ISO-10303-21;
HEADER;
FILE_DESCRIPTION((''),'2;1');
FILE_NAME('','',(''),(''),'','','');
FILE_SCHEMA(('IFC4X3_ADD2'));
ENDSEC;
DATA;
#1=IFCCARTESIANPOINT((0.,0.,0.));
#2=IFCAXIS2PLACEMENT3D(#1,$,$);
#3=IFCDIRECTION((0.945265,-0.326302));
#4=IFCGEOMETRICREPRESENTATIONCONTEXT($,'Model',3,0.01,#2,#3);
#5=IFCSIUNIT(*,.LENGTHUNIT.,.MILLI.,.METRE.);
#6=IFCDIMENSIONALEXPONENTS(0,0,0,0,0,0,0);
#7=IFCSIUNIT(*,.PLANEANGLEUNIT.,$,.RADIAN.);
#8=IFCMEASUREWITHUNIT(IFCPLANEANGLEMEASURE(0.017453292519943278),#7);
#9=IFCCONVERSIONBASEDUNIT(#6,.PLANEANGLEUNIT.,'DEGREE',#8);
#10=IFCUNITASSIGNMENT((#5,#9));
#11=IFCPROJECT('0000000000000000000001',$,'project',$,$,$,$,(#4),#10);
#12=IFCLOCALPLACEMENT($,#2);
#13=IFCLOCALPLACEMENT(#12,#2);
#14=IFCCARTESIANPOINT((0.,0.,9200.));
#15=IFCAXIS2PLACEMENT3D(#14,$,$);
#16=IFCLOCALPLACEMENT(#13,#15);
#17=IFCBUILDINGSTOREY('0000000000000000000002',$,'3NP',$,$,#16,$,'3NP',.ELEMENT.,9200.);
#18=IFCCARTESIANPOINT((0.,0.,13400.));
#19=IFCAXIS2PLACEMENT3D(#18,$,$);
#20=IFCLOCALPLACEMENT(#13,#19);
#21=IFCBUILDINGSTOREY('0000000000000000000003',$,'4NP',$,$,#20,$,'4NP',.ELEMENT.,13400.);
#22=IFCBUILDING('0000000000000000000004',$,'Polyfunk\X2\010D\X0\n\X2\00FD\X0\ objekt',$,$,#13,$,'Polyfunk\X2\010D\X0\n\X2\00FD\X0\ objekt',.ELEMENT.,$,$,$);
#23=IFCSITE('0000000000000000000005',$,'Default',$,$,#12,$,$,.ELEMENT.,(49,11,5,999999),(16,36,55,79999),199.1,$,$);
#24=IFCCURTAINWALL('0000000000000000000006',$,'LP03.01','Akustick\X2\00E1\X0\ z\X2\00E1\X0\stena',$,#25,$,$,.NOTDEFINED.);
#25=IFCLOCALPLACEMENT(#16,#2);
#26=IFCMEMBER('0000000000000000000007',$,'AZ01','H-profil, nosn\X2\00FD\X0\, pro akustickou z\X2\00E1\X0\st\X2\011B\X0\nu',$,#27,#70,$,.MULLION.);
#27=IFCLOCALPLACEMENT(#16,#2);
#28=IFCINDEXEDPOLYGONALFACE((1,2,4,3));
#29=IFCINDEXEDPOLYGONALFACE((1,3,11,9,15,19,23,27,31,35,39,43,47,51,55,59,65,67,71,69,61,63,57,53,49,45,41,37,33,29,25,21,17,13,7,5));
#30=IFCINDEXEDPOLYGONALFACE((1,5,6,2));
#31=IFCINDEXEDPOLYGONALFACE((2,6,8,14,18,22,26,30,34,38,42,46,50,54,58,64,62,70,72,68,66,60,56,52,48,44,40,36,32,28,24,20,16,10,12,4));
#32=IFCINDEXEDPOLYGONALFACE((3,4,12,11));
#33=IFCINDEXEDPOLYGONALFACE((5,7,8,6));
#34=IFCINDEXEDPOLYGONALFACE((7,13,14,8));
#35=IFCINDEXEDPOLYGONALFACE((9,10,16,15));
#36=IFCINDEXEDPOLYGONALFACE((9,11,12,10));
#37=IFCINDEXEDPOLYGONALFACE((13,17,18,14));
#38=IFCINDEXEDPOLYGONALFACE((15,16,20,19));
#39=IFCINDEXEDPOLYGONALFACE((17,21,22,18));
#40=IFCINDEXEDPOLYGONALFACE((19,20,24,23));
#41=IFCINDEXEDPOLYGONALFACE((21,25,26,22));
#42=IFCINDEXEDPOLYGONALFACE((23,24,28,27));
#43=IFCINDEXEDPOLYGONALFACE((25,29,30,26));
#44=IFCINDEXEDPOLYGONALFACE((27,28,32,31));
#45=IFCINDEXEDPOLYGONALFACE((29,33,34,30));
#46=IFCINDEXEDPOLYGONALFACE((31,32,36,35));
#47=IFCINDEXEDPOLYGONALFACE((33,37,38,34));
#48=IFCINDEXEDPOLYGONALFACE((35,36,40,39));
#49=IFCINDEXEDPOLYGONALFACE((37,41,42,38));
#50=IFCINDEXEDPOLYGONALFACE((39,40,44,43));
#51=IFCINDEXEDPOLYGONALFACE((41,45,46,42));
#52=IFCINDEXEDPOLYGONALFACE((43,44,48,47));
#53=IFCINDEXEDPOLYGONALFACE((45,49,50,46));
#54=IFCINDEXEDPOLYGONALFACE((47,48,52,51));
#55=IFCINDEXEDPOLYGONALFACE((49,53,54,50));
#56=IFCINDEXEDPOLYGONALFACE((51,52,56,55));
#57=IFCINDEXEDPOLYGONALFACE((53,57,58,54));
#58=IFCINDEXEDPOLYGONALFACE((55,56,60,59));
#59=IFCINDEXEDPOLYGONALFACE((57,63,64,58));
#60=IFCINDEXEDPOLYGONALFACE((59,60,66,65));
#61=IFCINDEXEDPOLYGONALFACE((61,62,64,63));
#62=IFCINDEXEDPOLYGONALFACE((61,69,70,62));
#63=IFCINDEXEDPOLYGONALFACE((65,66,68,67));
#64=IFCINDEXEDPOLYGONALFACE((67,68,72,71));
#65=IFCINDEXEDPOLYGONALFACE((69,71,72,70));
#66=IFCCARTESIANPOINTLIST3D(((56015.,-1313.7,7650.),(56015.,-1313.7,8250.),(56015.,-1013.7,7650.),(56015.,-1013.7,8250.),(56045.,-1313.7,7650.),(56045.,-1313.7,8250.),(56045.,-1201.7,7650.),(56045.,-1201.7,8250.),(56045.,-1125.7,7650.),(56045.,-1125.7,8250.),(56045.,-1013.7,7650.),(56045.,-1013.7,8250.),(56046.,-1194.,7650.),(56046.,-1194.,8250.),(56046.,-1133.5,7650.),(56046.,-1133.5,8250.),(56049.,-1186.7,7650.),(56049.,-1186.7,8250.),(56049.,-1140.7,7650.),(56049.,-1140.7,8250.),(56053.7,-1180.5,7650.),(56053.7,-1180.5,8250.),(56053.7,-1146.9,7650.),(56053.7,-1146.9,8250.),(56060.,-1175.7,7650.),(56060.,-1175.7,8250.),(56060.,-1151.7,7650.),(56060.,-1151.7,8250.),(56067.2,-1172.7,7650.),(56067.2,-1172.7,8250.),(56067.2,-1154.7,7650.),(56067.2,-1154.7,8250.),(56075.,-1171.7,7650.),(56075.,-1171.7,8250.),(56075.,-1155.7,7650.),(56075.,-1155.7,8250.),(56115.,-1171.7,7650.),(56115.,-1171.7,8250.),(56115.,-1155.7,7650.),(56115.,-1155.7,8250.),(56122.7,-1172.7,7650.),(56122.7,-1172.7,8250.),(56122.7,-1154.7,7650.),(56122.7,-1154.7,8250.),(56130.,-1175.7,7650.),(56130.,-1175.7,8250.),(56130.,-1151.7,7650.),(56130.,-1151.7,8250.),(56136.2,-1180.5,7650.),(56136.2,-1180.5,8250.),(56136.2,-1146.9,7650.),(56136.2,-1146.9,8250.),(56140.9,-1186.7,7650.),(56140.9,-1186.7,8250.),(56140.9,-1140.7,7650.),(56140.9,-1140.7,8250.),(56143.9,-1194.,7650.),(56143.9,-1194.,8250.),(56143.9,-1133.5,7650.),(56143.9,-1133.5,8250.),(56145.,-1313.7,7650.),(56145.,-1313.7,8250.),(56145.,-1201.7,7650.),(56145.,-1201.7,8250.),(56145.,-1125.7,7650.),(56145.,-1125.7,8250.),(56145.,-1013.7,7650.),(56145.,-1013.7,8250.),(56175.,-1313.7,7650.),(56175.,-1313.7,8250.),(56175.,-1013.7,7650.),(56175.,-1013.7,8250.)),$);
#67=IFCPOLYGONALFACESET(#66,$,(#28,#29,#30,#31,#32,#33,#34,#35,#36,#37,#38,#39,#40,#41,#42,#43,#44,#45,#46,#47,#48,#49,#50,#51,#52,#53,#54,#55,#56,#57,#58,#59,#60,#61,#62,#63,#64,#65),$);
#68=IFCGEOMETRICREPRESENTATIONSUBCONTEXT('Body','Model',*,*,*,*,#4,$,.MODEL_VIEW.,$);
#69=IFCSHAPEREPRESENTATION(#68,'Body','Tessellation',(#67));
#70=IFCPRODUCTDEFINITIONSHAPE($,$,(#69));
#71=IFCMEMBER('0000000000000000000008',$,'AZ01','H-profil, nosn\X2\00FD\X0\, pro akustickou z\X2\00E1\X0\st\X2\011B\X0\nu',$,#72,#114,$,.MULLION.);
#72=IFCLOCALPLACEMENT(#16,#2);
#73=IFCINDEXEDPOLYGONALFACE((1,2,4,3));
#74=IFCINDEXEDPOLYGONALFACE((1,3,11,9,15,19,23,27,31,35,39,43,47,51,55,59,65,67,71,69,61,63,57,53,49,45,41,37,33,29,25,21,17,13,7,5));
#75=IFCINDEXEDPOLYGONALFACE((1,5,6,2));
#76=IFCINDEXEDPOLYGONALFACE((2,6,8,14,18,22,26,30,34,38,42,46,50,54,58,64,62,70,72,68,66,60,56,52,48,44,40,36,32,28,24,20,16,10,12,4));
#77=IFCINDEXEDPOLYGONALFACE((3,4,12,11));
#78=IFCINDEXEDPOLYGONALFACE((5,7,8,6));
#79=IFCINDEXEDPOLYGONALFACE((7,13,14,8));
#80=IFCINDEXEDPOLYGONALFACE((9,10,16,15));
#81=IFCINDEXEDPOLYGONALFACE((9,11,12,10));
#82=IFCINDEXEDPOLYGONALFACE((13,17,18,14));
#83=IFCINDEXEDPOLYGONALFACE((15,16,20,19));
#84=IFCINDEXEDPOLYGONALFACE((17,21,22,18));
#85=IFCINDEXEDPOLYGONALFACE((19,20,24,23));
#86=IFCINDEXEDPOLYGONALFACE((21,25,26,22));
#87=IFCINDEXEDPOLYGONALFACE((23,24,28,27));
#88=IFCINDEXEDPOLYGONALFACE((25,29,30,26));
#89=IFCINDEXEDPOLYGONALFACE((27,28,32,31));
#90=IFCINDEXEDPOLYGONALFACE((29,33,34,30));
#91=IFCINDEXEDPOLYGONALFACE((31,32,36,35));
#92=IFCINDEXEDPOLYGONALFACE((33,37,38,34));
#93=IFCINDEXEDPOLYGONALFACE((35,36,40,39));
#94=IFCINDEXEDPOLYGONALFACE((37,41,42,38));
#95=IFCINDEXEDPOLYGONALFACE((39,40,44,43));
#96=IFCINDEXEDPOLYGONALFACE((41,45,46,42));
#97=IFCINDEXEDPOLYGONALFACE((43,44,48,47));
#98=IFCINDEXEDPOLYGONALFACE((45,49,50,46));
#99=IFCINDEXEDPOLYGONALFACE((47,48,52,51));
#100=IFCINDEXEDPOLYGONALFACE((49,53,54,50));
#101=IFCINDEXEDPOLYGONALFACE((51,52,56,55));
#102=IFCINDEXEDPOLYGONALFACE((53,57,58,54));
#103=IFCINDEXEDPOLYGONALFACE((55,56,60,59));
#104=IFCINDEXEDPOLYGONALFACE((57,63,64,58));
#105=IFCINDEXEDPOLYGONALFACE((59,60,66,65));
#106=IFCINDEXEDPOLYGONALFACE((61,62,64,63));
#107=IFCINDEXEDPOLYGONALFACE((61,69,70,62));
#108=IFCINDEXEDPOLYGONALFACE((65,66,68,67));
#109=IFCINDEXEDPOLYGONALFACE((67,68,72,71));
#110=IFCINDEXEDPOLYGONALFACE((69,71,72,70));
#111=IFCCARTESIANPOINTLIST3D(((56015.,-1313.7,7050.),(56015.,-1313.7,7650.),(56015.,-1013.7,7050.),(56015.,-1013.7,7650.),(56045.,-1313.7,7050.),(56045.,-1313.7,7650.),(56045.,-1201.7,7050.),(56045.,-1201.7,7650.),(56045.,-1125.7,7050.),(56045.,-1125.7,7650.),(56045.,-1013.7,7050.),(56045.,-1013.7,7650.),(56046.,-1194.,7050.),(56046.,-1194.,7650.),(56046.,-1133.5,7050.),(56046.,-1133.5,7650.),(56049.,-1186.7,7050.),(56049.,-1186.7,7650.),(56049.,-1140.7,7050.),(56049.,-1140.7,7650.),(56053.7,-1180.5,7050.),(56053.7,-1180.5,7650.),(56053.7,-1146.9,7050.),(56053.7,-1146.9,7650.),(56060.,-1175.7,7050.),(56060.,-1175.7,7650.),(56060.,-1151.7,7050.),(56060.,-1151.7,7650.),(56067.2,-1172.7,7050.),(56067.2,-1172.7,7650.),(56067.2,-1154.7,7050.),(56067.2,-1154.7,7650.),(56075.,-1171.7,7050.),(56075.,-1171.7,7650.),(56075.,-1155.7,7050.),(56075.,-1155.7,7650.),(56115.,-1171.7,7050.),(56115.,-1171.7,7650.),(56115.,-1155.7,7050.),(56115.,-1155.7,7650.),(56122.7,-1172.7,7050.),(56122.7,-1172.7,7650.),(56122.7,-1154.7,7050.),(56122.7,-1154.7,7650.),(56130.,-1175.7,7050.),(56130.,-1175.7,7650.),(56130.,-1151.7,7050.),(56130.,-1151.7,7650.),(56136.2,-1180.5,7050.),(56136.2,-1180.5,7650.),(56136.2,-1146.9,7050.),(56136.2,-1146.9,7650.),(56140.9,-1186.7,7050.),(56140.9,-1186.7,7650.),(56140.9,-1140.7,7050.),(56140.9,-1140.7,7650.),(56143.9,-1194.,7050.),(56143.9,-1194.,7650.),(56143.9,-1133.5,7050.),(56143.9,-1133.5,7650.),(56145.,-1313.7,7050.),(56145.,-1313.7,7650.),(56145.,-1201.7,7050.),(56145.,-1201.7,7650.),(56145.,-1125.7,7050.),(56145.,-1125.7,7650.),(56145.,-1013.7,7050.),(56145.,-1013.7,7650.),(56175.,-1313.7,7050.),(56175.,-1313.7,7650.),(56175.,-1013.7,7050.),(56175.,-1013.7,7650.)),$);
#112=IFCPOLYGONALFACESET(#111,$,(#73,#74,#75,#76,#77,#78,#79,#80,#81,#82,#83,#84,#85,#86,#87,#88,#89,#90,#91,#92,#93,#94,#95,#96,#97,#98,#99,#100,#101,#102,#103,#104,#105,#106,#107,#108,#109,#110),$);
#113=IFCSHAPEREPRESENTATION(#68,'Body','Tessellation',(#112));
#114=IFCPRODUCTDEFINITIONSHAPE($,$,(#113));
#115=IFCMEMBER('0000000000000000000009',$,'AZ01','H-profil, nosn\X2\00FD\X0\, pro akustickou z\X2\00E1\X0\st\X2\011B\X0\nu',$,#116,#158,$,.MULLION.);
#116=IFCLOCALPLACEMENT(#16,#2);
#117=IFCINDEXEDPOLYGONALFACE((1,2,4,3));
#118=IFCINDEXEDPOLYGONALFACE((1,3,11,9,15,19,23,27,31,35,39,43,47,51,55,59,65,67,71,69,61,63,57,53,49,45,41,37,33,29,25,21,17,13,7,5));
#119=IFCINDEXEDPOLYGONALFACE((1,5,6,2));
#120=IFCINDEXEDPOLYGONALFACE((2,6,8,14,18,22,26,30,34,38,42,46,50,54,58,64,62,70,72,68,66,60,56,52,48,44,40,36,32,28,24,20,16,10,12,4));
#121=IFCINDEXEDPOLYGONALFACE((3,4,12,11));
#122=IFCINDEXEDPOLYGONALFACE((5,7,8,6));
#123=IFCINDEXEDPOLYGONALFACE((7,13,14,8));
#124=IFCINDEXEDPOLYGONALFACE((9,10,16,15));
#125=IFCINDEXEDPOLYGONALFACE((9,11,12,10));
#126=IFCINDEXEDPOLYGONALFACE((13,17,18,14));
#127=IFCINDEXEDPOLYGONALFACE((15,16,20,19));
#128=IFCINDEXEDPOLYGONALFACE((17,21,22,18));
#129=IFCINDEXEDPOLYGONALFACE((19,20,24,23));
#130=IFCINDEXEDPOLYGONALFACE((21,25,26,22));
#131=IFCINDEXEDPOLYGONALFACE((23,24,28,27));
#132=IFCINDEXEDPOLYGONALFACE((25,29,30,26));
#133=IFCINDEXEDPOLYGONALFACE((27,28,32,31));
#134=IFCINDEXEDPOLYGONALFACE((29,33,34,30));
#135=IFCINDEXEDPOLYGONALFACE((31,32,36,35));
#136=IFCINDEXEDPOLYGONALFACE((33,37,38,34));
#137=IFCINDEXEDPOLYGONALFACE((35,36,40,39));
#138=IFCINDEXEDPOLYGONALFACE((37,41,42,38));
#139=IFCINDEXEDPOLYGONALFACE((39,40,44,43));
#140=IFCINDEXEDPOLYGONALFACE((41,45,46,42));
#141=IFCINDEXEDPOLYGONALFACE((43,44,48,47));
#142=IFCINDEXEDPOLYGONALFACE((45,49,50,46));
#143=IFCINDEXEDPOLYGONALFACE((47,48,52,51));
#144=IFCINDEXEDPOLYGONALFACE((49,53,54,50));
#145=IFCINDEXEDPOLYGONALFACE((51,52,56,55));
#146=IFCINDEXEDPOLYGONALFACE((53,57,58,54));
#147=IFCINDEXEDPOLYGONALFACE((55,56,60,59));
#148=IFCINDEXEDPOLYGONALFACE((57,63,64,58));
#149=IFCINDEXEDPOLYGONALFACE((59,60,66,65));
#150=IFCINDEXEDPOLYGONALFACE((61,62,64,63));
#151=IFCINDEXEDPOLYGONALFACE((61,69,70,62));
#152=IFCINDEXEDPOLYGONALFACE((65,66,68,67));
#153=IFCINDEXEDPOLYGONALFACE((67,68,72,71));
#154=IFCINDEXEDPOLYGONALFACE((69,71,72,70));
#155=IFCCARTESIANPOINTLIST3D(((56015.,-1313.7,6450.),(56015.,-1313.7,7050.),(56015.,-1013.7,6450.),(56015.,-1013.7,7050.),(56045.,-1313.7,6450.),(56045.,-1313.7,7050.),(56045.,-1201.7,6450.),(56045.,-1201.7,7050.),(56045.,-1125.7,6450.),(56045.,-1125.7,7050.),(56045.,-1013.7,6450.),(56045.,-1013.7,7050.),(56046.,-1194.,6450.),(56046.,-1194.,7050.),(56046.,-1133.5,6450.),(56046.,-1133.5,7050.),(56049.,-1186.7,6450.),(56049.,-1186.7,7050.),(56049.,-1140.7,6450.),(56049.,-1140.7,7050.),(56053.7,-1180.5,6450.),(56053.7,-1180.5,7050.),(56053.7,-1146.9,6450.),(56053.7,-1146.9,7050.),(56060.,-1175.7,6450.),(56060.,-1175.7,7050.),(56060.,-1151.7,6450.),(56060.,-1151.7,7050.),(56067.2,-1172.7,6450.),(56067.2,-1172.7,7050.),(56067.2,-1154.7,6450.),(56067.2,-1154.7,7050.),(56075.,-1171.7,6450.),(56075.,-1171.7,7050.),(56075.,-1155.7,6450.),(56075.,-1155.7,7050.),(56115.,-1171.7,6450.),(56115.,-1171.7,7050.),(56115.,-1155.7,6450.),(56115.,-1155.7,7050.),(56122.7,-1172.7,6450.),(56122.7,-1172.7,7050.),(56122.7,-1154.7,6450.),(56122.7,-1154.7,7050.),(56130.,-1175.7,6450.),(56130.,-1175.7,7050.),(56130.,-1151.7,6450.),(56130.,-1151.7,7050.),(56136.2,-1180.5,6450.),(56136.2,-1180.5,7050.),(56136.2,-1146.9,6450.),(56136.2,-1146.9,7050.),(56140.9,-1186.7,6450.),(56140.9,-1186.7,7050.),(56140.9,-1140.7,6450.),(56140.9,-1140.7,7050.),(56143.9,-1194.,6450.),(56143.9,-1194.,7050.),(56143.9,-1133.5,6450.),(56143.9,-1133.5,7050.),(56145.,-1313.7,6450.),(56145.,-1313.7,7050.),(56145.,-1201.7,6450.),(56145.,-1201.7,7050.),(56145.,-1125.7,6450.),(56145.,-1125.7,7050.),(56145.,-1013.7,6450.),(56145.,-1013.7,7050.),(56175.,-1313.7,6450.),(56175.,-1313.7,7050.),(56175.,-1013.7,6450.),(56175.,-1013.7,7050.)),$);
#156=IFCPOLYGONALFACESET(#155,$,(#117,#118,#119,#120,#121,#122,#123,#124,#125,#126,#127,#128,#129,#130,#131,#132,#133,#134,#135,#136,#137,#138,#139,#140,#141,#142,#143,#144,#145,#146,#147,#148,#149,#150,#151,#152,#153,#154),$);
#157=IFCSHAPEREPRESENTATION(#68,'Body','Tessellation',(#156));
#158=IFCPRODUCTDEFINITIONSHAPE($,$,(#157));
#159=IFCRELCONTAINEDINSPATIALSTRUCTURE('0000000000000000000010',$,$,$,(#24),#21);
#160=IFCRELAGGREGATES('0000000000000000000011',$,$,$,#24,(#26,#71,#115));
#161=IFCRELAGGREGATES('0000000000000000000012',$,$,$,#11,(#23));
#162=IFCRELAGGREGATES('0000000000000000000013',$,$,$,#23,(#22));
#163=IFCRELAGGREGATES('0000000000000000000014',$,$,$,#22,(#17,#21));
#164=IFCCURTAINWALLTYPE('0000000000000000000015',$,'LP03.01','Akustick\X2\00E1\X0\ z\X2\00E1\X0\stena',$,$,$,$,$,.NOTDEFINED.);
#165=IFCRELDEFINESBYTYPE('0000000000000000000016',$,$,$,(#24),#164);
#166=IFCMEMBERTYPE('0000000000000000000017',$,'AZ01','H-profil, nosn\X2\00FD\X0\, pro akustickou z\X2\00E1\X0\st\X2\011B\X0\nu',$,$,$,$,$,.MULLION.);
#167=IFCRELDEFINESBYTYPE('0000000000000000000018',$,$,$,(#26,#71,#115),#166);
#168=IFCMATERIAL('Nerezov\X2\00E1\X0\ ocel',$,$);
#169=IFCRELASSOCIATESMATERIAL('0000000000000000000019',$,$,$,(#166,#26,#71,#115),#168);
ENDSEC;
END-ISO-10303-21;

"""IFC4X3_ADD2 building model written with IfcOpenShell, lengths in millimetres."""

from ifc_helpers import new_model, entity, si_unit, converted_unit, direction, frame, frame_2d, origin, place, context, subcontext, project, spatial, polyline, circle_curve, parameter, trimmed, segment, composite_curve, outline, extrude, source, transform, mapped, material, material_profile, profile_set, profile_usage, type_object, element, aggregate, save


model = new_model("IFC4X3_ADD2")

# Units and contexts
model_context = context("Model", 3, precision=0.01, world=origin(), true_north=direction((0.945265, -0.326302)))
body_context = subcontext(model_context, "Body", "Model", "MODEL_VIEW")
ifc_project = project(units=[si_unit("LENGTHUNIT", "METRE", prefix="MILLI"), converted_unit("PLANEANGLEUNIT", "DEGREE", entity("IfcPlaneAngleMeasure", 0.017453292519943278), si_unit("PLANEANGLEUNIT", "RADIAN"), dimensions=[0, 0, 0, 0, 0, 0, 0])], contexts=[model_context])

# Site, building, storey
site_placement = place(None, origin())
site = spatial("IfcSite", under=ifc_project, at=site_placement, Name="Default", CompositionType="ELEMENT", RefLatitude=(49, 11, 5, 999999), RefLongitude=(16, 36, 55, 79999), RefElevation=199.1)
building_placement = place(site_placement, origin())
building = spatial("IfcBuilding", under=site, at=building_placement, Name="Polyfunkčný objekt", LongName="Polyfunkčný objekt", CompositionType="ELEMENT")
storey_1_placement = place(building_placement, frame((0.0, 0.0, 9200.0)))
storey_1 = spatial("IfcBuildingStorey", under=building, at=storey_1_placement, Name="3NP", LongName="3NP", CompositionType="ELEMENT", Elevation=9200.0)

# Shared definitions
storey_2_placement = place(building_placement, frame((0.0, 0.0, 13400.0)))
storey_2 = spatial("IfcBuildingStorey", under=building, at=storey_2_placement, Name="4NP", LongName="4NP", CompositionType="ELEMENT", Elevation=13400.0)

# Curtain wall, members
curtain_wall_type_1 = type_object("IfcCurtainWallType", Name="LP03.01", Description="Akustická zástena", PredefinedType="NOTDEFINED")
ifc_material_1 = material(Name="Nerezová ocel")
ifc_material_profile_1 = material_profile(ifc_material_1, outline(composite_curve([segment(polyline([(50.0, -150.0), (80.0, -150.0)]), True, "CONTINUOUS"), segment(polyline([(80.0, -150.0), (80.0, 150.0)]), True, "CONTINUOUS"), segment(polyline([(80.0, 150.0), (50.0, 150.0)]), True, "CONTINUOUS"), segment(polyline([(50.0, 150.0), (50.0, 38.0)]), True, "CONTINUOUS"), segment(trimmed(circle_curve(frame_2d((20.0, 38.0), x_axis=(0.0, 1.0)), 30.0), [parameter(180.0)], [parameter(270.0)], True, "PARAMETER"), False, "CONTINUOUS"), segment(polyline([(20.0, 8.0), (-20.0, 8.0)]), True, "CONTINUOUS"), segment(trimmed(circle_curve(frame_2d((-20.0, 38.0), x_axis=(0.0, 1.0)), 30.0), [parameter(90.0)], [parameter(180.0)], True, "PARAMETER"), False, "CONTINUOUS"), segment(polyline([(-50.0, 38.0), (-50.0, 150.0)]), True, "CONTINUOUS"), segment(polyline([(-50.0, 150.0), (-80.0, 150.0)]), True, "CONTINUOUS"), segment(polyline([(-80.0, 150.0), (-80.0, -150.0)]), True, "CONTINUOUS"), segment(polyline([(-80.0, -150.0), (-50.0, -150.0)]), True, "CONTINUOUS"), segment(polyline([(-50.0, -150.0), (-50.0, -38.0)]), True, "CONTINUOUS"), segment(trimmed(circle_curve(frame_2d((-20.0, -38.0), x_axis=(0.0, 1.0)), 30.0), [parameter(0.0)], [parameter(90.0)], True, "PARAMETER"), False, "CONTINUOUS"), segment(polyline([(-20.0, -8.0), (20.0, -8.0)]), True, "CONTINUOUS"), segment(trimmed(circle_curve(frame_2d((20.0, -38.0), x_axis=(0.0, 1.0)), 30.0), [parameter(270.0)], [parameter(0.0)], True, "PARAMETER"), False, "CONTINUOUS"), segment(polyline([(50.0, -38.0), (50.0, -150.0)]), True, "CONTINUOUS")], self_intersect=False)), Name="Profil zástena")
ifc_profile_set_1 = profile_set([ifc_material_profile_1], Name="Profil zástena")
ifc_profile_usage_1 = profile_usage(ifc_profile_set_1)
member_type_1 = type_object("IfcMemberType", Name="AZ01", Description="H-profil, nosný, pro akustickou zástěnu", PredefinedType="MULLION", material=ifc_profile_set_1)
curtain_wall_1_placement = place(storey_2_placement, frame((0.0, 0.0, -13400.0)))
curtain_wall_1 = element("IfcCurtainWall", 1, at=curtain_wall_1_placement, inside=storey_2, type_object=curtain_wall_type_1, Name="LP03.01", Description="Akustická zástena", PredefinedType="NOTDEFINED")
shared_shape_1 = source(origin(), body_context, "Body", "SweptSolid", [
    extrude(outline(composite_curve([segment(polyline([(50.0, -150.0), (80.0, -150.0)]), True, "CONTINUOUS"), segment(polyline([(80.0, -150.0), (80.0, 150.0)]), True, "CONTINUOUS"), segment(polyline([(80.0, 150.0), (50.0, 150.0)]), True, "CONTINUOUS"), segment(polyline([(50.0, 150.0), (50.0, 38.0)]), True, "CONTINUOUS"), segment(trimmed(circle_curve(frame_2d((20.0, 38.0), x_axis=(0.0, 1.0)), 30.0), [parameter(180.0)], [parameter(270.0)], True, "PARAMETER"), False, "CONTINUOUS"), segment(polyline([(20.0, 8.0), (-20.0, 8.0)]), True, "CONTINUOUS"), segment(trimmed(circle_curve(frame_2d((-20.0, 38.0), x_axis=(0.0, 1.0)), 30.0), [parameter(90.0)], [parameter(180.0)], True, "PARAMETER"), False, "CONTINUOUS"), segment(polyline([(-50.0, 38.0), (-50.0, 150.0)]), True, "CONTINUOUS"), segment(polyline([(-50.0, 150.0), (-80.0, 150.0)]), True, "CONTINUOUS"), segment(polyline([(-80.0, 150.0), (-80.0, -150.0)]), True, "CONTINUOUS"), segment(polyline([(-80.0, -150.0), (-50.0, -150.0)]), True, "CONTINUOUS"), segment(polyline([(-50.0, -150.0), (-50.0, -38.0)]), True, "CONTINUOUS"), segment(trimmed(circle_curve(frame_2d((-20.0, -38.0), x_axis=(0.0, 1.0)), 30.0), [parameter(0.0)], [parameter(90.0)], True, "PARAMETER"), False, "CONTINUOUS"), segment(polyline([(-20.0, -8.0), (20.0, -8.0)]), True, "CONTINUOUS"), segment(trimmed(circle_curve(frame_2d((20.0, -38.0), x_axis=(0.0, 1.0)), 30.0), [parameter(270.0)], [parameter(0.0)], True, "PARAMETER"), False, "CONTINUOUS"), segment(polyline([(50.0, -38.0), (50.0, -150.0)]), True, "CONTINUOUS")], self_intersect=False)), frame((-150.0, 0.0, -600.0), z_axis=(0.0, 0.0, 1.0), x_axis=(0.0, 1.0, 0.0)), (0.0, 0.0, 1.0), 600.0),
])
member_1_placement = place(curtain_wall_1_placement, frame((56095.0, -1313.7, 17450.0), z_axis=(0.0, 0.0, 1.0), x_axis=(0.0, -1.0, 0.0)))
member_1 = element("IfcMember", 2, at=member_1_placement, type_object=member_type_1, material=ifc_profile_usage_1, Name="AZ01", Description="H-profil, nosný, pro akustickou zástěnu", PredefinedType="MULLION", context=body_context, shape_type="MappedRepresentation", body=[
    mapped(shared_shape_1, transform((0.0, 0.0, 0.0), scale=1.0)),
])
member_2_placement = place(curtain_wall_1_placement, frame((56095.0, -1313.7, 16850.0), z_axis=(0.0, 0.0, 1.0), x_axis=(0.0, -1.0, 0.0)))
member_2 = element("IfcMember", 3, at=member_2_placement, type_object=member_type_1, material=ifc_profile_usage_1, Name="AZ01", Description="H-profil, nosný, pro akustickou zástěnu", PredefinedType="MULLION", context=body_context, shape_type="MappedRepresentation", body=[
    mapped(shared_shape_1, transform((0.0, 0.0, 0.0), scale=1.0)),
])
member_3_placement = place(curtain_wall_1_placement, frame((56095.0, -1313.7, 16250.0), z_axis=(0.0, 0.0, 1.0), x_axis=(0.0, -1.0, 0.0)))
member_3 = element("IfcMember", 4, at=member_3_placement, type_object=member_type_1, material=ifc_profile_usage_1, Name="AZ01", Description="H-profil, nosný, pro akustickou zástěnu", PredefinedType="MULLION", context=body_context, shape_type="MappedRepresentation", body=[
    mapped(shared_shape_1, transform((0.0, 0.0, 0.0), scale=1.0)),
])

aggregate(curtain_wall_1, [member_1, member_2, member_3])

save(model, "model.ifc")
